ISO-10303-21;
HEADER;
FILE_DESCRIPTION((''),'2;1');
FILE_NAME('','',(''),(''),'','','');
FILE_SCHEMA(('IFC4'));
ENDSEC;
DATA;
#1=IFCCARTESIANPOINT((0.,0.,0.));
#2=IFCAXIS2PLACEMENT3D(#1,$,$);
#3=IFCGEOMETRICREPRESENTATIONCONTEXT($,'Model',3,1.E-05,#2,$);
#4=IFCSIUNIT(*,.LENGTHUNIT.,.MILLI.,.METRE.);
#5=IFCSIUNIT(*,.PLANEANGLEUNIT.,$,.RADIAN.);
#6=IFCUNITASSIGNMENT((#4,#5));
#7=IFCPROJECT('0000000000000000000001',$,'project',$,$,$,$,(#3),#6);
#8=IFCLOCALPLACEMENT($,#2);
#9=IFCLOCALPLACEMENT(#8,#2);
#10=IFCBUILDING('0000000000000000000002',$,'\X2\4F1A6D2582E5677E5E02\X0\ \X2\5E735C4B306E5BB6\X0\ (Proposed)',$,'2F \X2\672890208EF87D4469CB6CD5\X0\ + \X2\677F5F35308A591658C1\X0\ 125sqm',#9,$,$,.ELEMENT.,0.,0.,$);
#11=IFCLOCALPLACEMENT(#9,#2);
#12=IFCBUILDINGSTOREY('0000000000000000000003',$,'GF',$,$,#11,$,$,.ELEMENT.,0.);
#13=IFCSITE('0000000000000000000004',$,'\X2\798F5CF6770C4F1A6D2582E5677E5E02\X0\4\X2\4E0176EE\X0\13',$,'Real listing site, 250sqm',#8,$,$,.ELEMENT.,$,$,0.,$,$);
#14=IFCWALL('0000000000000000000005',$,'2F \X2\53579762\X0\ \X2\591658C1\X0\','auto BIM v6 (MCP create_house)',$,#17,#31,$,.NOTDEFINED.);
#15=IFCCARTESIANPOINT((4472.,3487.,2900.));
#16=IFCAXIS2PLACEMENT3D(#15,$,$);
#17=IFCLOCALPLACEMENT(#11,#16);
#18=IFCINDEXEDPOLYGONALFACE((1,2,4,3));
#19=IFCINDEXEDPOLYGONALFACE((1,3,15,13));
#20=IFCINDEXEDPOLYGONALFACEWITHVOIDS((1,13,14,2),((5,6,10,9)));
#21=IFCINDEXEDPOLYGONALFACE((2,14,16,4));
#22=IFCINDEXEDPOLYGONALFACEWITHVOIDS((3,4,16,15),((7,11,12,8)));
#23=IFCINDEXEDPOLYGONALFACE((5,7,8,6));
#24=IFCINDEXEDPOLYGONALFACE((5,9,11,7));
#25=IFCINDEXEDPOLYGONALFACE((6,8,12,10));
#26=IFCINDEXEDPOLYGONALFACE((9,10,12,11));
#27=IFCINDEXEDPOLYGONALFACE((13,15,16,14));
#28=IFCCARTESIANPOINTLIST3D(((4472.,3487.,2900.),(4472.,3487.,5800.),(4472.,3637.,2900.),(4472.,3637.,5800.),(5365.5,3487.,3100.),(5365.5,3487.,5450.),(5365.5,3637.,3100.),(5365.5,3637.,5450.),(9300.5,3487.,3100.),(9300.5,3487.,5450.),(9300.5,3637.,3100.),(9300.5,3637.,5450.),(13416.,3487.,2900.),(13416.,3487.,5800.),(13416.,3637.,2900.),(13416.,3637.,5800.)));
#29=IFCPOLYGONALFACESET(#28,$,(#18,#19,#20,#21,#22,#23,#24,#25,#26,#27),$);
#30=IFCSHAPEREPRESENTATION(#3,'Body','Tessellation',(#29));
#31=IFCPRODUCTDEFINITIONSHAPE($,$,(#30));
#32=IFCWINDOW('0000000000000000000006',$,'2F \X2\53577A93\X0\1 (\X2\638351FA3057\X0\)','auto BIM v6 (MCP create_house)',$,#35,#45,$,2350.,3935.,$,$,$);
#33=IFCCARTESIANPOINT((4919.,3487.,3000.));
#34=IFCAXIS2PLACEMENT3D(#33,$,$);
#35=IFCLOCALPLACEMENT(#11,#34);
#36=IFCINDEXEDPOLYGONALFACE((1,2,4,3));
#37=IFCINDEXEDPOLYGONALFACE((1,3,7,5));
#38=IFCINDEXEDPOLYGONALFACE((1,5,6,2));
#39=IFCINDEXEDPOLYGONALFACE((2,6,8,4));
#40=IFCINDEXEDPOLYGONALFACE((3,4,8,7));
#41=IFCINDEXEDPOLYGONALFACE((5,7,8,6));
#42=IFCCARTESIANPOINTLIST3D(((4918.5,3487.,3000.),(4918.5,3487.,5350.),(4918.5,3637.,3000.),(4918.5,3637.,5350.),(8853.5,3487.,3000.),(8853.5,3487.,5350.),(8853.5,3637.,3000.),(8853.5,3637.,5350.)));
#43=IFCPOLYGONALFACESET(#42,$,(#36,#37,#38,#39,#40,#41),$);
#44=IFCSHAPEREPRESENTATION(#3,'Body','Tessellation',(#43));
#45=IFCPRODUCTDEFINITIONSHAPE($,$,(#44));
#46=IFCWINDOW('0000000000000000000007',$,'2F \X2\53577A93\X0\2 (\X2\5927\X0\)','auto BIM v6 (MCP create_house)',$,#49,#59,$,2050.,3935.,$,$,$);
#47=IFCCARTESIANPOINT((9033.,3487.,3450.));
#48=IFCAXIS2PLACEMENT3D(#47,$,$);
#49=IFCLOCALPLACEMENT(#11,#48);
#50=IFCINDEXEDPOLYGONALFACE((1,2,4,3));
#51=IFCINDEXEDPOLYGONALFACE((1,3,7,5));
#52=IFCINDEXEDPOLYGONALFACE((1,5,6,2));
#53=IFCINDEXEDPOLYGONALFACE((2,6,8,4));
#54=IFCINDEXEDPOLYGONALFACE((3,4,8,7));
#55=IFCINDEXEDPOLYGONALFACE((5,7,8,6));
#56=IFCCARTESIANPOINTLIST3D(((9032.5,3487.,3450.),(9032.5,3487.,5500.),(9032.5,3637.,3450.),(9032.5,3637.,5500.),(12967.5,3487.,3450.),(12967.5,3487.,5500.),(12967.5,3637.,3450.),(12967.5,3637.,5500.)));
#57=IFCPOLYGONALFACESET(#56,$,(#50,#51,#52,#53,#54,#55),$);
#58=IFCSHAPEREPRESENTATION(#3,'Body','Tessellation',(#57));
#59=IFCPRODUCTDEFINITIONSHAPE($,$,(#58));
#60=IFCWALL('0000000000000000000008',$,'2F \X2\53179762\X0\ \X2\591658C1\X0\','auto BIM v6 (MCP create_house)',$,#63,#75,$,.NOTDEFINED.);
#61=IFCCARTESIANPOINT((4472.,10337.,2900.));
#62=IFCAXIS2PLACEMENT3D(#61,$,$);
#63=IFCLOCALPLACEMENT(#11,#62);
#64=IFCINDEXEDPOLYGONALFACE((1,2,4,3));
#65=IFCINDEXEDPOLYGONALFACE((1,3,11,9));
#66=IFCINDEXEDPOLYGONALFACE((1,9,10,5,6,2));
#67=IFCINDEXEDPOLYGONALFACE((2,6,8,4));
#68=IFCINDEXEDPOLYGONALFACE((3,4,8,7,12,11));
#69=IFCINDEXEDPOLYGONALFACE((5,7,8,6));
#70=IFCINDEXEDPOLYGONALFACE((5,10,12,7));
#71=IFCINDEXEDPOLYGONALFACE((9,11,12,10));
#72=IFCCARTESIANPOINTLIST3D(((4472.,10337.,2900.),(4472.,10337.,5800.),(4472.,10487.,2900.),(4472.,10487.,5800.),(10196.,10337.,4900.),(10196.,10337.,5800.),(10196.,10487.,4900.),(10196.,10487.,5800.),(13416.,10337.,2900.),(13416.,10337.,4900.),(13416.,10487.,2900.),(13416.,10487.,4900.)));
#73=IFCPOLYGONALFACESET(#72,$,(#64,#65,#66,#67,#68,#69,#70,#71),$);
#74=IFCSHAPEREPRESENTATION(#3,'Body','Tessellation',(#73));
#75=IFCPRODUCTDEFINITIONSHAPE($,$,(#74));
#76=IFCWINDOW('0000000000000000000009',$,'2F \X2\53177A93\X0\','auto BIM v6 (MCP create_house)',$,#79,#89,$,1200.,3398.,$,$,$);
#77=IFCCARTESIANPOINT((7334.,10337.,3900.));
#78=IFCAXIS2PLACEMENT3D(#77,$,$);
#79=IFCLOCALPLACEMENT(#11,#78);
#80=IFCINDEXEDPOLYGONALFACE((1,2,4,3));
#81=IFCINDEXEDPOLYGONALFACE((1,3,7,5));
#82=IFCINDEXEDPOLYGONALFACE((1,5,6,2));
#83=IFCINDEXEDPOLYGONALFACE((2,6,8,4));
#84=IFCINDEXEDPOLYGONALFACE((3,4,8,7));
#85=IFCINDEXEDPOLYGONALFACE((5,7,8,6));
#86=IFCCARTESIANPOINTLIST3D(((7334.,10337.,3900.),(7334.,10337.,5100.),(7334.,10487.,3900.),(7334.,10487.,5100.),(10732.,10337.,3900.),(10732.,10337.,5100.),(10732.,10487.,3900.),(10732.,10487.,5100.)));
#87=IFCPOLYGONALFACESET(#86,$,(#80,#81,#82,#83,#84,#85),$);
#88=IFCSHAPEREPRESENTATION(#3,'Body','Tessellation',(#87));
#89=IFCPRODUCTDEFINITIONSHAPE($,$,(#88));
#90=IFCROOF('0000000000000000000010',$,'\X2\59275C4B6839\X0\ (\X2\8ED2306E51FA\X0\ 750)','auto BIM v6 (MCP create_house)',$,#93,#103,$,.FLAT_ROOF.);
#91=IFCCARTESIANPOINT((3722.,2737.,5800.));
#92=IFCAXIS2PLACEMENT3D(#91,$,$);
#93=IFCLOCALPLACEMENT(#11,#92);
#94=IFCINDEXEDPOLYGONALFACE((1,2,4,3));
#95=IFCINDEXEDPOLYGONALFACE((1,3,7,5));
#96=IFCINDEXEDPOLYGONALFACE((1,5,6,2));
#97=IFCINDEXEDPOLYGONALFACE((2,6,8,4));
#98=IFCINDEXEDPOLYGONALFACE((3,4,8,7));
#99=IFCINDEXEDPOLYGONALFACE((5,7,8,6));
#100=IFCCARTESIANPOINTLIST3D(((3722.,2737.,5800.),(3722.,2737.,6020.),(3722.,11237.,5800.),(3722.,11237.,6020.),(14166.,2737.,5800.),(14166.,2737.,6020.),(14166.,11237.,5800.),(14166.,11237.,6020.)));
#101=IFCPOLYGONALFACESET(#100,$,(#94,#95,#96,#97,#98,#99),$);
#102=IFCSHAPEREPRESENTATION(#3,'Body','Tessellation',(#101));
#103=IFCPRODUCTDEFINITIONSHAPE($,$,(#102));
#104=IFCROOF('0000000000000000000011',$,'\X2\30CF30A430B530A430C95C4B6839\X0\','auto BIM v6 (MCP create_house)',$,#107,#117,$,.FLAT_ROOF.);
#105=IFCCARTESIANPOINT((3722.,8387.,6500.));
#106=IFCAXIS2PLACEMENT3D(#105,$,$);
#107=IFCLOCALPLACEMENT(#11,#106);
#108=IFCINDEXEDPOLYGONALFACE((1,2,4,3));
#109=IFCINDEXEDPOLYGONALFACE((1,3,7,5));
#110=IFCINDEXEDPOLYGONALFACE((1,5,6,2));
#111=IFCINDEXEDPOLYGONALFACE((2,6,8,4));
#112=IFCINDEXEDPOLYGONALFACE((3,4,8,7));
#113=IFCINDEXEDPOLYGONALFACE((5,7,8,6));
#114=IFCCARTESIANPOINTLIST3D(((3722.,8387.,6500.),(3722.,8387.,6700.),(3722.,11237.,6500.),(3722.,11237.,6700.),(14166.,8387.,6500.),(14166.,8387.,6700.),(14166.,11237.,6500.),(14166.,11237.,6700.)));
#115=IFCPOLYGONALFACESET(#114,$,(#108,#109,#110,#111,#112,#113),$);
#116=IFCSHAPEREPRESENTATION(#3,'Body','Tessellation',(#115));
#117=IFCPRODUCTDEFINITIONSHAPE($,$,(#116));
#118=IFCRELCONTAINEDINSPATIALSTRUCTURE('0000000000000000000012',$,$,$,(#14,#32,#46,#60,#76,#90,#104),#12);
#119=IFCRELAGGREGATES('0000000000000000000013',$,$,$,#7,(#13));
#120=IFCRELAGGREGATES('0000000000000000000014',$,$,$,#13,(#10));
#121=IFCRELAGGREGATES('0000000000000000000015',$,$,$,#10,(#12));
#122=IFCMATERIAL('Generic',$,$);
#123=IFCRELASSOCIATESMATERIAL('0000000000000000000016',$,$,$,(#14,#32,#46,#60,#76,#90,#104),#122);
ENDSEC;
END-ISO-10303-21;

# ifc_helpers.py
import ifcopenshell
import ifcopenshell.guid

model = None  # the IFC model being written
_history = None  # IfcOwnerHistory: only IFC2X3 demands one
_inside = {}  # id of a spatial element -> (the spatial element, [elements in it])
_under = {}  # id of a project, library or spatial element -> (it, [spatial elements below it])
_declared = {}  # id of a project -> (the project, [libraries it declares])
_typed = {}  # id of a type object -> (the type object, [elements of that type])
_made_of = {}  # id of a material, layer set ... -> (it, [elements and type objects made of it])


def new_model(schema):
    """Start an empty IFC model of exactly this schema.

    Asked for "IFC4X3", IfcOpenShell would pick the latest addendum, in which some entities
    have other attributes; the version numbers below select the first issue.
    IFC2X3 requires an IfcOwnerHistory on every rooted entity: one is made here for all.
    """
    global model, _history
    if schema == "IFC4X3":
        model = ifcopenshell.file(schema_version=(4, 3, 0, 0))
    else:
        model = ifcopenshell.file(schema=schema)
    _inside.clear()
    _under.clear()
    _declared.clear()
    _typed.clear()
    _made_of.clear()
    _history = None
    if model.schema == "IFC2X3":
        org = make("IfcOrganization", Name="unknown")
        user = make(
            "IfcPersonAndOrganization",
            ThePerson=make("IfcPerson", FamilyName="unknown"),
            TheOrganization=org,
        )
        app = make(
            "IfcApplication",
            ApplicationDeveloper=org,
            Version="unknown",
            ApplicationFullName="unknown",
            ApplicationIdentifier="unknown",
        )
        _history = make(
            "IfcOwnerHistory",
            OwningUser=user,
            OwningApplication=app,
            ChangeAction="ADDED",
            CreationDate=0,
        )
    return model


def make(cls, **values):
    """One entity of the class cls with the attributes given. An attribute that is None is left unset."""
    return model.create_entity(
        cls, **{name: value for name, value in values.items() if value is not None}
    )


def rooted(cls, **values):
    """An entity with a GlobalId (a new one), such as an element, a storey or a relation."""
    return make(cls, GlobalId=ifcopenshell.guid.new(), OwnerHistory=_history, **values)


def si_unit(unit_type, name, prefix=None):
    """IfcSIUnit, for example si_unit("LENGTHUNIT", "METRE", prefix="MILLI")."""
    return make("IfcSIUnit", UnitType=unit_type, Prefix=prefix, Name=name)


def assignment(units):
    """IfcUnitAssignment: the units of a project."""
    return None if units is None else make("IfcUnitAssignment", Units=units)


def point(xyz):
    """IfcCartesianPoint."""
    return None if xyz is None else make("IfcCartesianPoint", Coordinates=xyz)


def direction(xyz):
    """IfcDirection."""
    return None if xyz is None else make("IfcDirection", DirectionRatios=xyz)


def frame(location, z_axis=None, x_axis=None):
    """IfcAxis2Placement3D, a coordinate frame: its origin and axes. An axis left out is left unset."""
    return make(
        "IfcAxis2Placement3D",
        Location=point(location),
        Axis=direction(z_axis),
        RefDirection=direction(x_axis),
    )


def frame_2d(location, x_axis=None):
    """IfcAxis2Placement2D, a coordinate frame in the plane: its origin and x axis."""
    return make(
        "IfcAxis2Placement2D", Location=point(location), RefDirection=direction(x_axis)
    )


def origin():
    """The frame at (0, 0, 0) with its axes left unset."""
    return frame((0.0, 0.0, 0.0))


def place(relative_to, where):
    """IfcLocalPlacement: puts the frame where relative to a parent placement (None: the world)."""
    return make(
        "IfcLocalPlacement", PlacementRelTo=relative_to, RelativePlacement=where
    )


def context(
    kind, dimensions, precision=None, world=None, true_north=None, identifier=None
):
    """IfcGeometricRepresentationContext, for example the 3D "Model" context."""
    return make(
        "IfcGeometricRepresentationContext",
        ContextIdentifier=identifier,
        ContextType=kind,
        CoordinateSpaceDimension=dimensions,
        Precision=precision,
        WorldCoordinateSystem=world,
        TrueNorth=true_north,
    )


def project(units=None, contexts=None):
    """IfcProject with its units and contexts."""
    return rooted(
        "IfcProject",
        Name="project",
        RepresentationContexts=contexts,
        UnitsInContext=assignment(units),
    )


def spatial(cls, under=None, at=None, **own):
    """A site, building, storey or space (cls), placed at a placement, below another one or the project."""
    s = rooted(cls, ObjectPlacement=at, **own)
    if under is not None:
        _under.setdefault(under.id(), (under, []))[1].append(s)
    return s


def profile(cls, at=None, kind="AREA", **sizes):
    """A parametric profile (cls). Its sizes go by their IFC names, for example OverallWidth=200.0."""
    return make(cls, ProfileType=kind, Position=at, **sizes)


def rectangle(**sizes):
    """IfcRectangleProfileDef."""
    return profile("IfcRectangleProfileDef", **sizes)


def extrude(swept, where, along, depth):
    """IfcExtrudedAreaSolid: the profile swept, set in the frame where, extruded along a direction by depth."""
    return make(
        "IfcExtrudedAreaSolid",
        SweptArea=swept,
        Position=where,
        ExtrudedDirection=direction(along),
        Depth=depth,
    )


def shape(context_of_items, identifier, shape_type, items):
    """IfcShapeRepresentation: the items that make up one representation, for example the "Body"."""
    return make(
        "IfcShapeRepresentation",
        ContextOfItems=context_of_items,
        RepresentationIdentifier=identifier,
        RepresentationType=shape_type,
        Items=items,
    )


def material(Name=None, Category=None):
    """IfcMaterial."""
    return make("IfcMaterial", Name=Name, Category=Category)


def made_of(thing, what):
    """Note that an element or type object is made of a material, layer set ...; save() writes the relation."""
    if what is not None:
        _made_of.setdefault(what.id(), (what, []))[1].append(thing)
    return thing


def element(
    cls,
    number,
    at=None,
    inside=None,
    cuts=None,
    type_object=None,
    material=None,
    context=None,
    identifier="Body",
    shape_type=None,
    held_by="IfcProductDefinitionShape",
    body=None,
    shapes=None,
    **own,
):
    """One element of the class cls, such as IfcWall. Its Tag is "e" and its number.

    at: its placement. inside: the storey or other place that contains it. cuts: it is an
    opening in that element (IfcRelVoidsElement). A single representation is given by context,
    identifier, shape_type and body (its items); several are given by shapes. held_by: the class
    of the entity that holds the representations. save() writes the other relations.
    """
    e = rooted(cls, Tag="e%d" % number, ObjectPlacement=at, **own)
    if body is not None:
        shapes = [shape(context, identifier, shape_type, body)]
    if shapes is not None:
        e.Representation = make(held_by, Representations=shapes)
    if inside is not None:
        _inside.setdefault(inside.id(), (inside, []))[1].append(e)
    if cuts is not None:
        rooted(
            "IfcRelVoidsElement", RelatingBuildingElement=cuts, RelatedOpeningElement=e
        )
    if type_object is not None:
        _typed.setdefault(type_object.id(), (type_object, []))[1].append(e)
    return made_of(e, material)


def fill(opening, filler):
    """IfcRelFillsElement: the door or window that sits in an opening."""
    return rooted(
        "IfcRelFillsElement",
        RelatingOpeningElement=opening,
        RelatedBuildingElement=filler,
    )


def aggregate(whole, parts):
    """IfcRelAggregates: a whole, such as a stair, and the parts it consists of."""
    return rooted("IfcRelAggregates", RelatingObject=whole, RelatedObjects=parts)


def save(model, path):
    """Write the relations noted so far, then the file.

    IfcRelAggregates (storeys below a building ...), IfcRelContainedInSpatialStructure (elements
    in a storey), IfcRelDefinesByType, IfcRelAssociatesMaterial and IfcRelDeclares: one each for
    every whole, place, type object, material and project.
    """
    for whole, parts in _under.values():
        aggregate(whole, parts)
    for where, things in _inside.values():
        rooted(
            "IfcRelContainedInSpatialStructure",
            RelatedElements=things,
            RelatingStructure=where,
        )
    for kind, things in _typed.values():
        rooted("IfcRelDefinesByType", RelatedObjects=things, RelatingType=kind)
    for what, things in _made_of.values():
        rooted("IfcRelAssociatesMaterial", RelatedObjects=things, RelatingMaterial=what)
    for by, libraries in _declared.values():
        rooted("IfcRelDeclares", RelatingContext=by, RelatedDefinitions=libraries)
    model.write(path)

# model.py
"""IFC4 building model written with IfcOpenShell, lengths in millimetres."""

from ifc_helpers import new_model, si_unit, frame, frame_2d, origin, place, context, project, spatial, rectangle, extrude, material, element, fill, save


model = new_model("IFC4")

# Units and contexts
model_context = context("Model", 3, precision=1e-05, world=origin())
ifc_project = project(units=[si_unit("LENGTHUNIT", "METRE", prefix="MILLI"), si_unit("PLANEANGLEUNIT", "RADIAN")], contexts=[model_context])

# Site, building, storey
site_placement = place(None, origin())
site = spatial("IfcSite", under=ifc_project, at=site_placement, Name="福島県会津若松市4丁目13", ObjectType="Real listing site, 250sqm", CompositionType="ELEMENT", RefElevation=0.0)
building_placement = place(site_placement, origin())
building = spatial("IfcBuilding", under=site, at=building_placement, Name="会津若松市 平屋の家 (Proposed)", ObjectType="2F 木造軸組構法 + 板張り外壁 125sqm", CompositionType="ELEMENT", ElevationOfRefHeight=0.0, ElevationOfTerrain=0.0)
storey_placement = place(building_placement, origin())
storey = spatial("IfcBuildingStorey", under=building, at=storey_placement, Name="GF", CompositionType="ELEMENT", Elevation=0.0)

# Shared definitions
ifc_material = material(Name="Generic")

# Wall, openings, windows
wall_1_placement = place(storey_placement, frame((4472.0, 3487.0, 2900.0)))
wall_1 = element("IfcWall", 1, at=wall_1_placement, inside=storey, material=ifc_material, Name="2F 南面 外壁", Description="auto BIM v6 (MCP create_house)", PredefinedType="NOTDEFINED", context=model_context, shape_type="SweptSolid", body=[
    extrude(rectangle(XDim=8944.0, YDim=150.0, at=frame_2d((4472.0, 75.0))), frame((4472.0, 3487.0, 2900.0)), (0.0, 0.0, 1.0), 2900.0),
])
opening_1_placement = place(storey_placement, frame((4919.0, 3487.0, 3000.0)))
opening_1 = element("IfcOpeningElement", 2, at=opening_1_placement, cuts=wall_1, PredefinedType="NOTDEFINED", context=model_context, shape_type="SweptSolid", body=[
    extrude(rectangle(XDim=3935.0, YDim=150.0, at=frame_2d((1967.0, 75.0))), frame((4919.0, 3487.0, 3000.0)), (0.0, 0.0, 1.0), 2350.0),
])
opening_2_placement = place(storey_placement, frame((9033.0, 3487.0, 3450.0)))
opening_2 = element("IfcOpeningElement", 3, at=opening_2_placement, cuts=wall_1, PredefinedType="NOTDEFINED", context=model_context, shape_type="SweptSolid", body=[
    extrude(rectangle(XDim=3935.0, YDim=150.0, at=frame_2d((1967.0, 75.0))), frame((9033.0, 3487.0, 3450.0)), (0.0, 0.0, 1.0), 2050.0),
])
window_1_placement = place(storey_placement, frame((4919.0, 3487.0, 3000.0)))
window_1 = element("IfcWindow", 4, at=window_1_placement, inside=storey, material=ifc_material, Name="2F 南窓1 (掃出し)", Description="auto BIM v6 (MCP create_house)", OverallHeight=2350.0, OverallWidth=3935.0, context=model_context, shape_type="SweptSolid", body=[
    extrude(rectangle(XDim=3935.0, YDim=150.0, at=frame_2d((1967.0, 75.0))), frame((4919.0, 3487.0, 3000.0)), (0.0, 0.0, 1.0), 2350.0),
])
fill(opening_1, window_1)
window_2_placement = place(storey_placement, frame((9033.0, 3487.0, 3450.0)))
window_2 = element("IfcWindow", 5, at=window_2_placement, inside=storey, material=ifc_material, Name="2F 南窓2 (大)", Description="auto BIM v6 (MCP create_house)", OverallHeight=2050.0, OverallWidth=3935.0, context=model_context, shape_type="SweptSolid", body=[
    extrude(rectangle(XDim=3935.0, YDim=150.0, at=frame_2d((1967.0, 75.0))), frame((9033.0, 3487.0, 3450.0)), (0.0, 0.0, 1.0), 2050.0),
])
fill(opening_2, window_2)

# Wall, opening, window
wall_2_placement = place(storey_placement, frame((4472.0, 10337.0, 2900.0)))
wall_2 = element("IfcWall", 6, at=wall_2_placement, inside=storey, material=ifc_material, Name="2F 北面 外壁", Description="auto BIM v6 (MCP create_house)", PredefinedType="NOTDEFINED", context=model_context, shape_type="SweptSolid", body=[
    extrude(rectangle(XDim=8944.0, YDim=150.0, at=frame_2d((4472.0, 75.0))), frame((4472.0, 10337.0, 2900.0)), (0.0, 0.0, 1.0), 2900.0),
])
opening_3_placement = place(storey_placement, frame((7334.0, 10337.0, 3900.0)))
opening_3 = element("IfcOpeningElement", 7, at=opening_3_placement, cuts=wall_2, PredefinedType="NOTDEFINED", context=model_context, shape_type="SweptSolid", body=[
    extrude(rectangle(XDim=3398.0, YDim=150.0, at=frame_2d((1699.0, 75.0))), frame((7334.0, 10337.0, 3900.0)), (0.0, 0.0, 1.0), 1200.0),
])
window_3_placement = place(storey_placement, frame((7334.0, 10337.0, 3900.0)))
window_3 = element("IfcWindow", 8, at=window_3_placement, inside=storey, material=ifc_material, Name="2F 北窓", Description="auto BIM v6 (MCP create_house)", OverallHeight=1200.0, OverallWidth=3398.0, context=model_context, shape_type="SweptSolid", body=[
    extrude(rectangle(XDim=3398.0, YDim=150.0, at=frame_2d((1699.0, 75.0))), frame((7334.0, 10337.0, 3900.0)), (0.0, 0.0, 1.0), 1200.0),
])
fill(opening_3, window_3)

# Roofs
roof_1_placement = place(storey_placement, frame((3722.0, 2737.0, 5800.0)))
element("IfcRoof", 9, at=roof_1_placement, inside=storey, material=ifc_material, Name="大屋根 (軒の出 750)", Description="auto BIM v6 (MCP create_house)", PredefinedType="FLAT_ROOF", context=model_context, shape_type="SweptSolid", body=[
    extrude(rectangle(XDim=10444.0, YDim=8500.0, at=frame_2d((5222.0, 4250.0))), frame((3722.0, 2737.0, 5800.0)), (0.0, 0.0, 1.0), 220.0),
])
roof_2_placement = place(storey_placement, frame((3722.0, 8387.0, 6500.0)))
element("IfcRoof", 10, at=roof_2_placement, inside=storey, material=ifc_material, Name="ハイサイド屋根", Description="auto BIM v6 (MCP create_house)", PredefinedType="FLAT_ROOF", context=model_context, shape_type="SweptSolid", body=[
    extrude(rectangle(XDim=10444.0, YDim=2850.0, at=frame_2d((5222.0, 1425.0))), frame((3722.0, 8387.0, 6500.0)), (0.0, 0.0, 1.0), 200.0),
])

save(model, "model.ifc")
